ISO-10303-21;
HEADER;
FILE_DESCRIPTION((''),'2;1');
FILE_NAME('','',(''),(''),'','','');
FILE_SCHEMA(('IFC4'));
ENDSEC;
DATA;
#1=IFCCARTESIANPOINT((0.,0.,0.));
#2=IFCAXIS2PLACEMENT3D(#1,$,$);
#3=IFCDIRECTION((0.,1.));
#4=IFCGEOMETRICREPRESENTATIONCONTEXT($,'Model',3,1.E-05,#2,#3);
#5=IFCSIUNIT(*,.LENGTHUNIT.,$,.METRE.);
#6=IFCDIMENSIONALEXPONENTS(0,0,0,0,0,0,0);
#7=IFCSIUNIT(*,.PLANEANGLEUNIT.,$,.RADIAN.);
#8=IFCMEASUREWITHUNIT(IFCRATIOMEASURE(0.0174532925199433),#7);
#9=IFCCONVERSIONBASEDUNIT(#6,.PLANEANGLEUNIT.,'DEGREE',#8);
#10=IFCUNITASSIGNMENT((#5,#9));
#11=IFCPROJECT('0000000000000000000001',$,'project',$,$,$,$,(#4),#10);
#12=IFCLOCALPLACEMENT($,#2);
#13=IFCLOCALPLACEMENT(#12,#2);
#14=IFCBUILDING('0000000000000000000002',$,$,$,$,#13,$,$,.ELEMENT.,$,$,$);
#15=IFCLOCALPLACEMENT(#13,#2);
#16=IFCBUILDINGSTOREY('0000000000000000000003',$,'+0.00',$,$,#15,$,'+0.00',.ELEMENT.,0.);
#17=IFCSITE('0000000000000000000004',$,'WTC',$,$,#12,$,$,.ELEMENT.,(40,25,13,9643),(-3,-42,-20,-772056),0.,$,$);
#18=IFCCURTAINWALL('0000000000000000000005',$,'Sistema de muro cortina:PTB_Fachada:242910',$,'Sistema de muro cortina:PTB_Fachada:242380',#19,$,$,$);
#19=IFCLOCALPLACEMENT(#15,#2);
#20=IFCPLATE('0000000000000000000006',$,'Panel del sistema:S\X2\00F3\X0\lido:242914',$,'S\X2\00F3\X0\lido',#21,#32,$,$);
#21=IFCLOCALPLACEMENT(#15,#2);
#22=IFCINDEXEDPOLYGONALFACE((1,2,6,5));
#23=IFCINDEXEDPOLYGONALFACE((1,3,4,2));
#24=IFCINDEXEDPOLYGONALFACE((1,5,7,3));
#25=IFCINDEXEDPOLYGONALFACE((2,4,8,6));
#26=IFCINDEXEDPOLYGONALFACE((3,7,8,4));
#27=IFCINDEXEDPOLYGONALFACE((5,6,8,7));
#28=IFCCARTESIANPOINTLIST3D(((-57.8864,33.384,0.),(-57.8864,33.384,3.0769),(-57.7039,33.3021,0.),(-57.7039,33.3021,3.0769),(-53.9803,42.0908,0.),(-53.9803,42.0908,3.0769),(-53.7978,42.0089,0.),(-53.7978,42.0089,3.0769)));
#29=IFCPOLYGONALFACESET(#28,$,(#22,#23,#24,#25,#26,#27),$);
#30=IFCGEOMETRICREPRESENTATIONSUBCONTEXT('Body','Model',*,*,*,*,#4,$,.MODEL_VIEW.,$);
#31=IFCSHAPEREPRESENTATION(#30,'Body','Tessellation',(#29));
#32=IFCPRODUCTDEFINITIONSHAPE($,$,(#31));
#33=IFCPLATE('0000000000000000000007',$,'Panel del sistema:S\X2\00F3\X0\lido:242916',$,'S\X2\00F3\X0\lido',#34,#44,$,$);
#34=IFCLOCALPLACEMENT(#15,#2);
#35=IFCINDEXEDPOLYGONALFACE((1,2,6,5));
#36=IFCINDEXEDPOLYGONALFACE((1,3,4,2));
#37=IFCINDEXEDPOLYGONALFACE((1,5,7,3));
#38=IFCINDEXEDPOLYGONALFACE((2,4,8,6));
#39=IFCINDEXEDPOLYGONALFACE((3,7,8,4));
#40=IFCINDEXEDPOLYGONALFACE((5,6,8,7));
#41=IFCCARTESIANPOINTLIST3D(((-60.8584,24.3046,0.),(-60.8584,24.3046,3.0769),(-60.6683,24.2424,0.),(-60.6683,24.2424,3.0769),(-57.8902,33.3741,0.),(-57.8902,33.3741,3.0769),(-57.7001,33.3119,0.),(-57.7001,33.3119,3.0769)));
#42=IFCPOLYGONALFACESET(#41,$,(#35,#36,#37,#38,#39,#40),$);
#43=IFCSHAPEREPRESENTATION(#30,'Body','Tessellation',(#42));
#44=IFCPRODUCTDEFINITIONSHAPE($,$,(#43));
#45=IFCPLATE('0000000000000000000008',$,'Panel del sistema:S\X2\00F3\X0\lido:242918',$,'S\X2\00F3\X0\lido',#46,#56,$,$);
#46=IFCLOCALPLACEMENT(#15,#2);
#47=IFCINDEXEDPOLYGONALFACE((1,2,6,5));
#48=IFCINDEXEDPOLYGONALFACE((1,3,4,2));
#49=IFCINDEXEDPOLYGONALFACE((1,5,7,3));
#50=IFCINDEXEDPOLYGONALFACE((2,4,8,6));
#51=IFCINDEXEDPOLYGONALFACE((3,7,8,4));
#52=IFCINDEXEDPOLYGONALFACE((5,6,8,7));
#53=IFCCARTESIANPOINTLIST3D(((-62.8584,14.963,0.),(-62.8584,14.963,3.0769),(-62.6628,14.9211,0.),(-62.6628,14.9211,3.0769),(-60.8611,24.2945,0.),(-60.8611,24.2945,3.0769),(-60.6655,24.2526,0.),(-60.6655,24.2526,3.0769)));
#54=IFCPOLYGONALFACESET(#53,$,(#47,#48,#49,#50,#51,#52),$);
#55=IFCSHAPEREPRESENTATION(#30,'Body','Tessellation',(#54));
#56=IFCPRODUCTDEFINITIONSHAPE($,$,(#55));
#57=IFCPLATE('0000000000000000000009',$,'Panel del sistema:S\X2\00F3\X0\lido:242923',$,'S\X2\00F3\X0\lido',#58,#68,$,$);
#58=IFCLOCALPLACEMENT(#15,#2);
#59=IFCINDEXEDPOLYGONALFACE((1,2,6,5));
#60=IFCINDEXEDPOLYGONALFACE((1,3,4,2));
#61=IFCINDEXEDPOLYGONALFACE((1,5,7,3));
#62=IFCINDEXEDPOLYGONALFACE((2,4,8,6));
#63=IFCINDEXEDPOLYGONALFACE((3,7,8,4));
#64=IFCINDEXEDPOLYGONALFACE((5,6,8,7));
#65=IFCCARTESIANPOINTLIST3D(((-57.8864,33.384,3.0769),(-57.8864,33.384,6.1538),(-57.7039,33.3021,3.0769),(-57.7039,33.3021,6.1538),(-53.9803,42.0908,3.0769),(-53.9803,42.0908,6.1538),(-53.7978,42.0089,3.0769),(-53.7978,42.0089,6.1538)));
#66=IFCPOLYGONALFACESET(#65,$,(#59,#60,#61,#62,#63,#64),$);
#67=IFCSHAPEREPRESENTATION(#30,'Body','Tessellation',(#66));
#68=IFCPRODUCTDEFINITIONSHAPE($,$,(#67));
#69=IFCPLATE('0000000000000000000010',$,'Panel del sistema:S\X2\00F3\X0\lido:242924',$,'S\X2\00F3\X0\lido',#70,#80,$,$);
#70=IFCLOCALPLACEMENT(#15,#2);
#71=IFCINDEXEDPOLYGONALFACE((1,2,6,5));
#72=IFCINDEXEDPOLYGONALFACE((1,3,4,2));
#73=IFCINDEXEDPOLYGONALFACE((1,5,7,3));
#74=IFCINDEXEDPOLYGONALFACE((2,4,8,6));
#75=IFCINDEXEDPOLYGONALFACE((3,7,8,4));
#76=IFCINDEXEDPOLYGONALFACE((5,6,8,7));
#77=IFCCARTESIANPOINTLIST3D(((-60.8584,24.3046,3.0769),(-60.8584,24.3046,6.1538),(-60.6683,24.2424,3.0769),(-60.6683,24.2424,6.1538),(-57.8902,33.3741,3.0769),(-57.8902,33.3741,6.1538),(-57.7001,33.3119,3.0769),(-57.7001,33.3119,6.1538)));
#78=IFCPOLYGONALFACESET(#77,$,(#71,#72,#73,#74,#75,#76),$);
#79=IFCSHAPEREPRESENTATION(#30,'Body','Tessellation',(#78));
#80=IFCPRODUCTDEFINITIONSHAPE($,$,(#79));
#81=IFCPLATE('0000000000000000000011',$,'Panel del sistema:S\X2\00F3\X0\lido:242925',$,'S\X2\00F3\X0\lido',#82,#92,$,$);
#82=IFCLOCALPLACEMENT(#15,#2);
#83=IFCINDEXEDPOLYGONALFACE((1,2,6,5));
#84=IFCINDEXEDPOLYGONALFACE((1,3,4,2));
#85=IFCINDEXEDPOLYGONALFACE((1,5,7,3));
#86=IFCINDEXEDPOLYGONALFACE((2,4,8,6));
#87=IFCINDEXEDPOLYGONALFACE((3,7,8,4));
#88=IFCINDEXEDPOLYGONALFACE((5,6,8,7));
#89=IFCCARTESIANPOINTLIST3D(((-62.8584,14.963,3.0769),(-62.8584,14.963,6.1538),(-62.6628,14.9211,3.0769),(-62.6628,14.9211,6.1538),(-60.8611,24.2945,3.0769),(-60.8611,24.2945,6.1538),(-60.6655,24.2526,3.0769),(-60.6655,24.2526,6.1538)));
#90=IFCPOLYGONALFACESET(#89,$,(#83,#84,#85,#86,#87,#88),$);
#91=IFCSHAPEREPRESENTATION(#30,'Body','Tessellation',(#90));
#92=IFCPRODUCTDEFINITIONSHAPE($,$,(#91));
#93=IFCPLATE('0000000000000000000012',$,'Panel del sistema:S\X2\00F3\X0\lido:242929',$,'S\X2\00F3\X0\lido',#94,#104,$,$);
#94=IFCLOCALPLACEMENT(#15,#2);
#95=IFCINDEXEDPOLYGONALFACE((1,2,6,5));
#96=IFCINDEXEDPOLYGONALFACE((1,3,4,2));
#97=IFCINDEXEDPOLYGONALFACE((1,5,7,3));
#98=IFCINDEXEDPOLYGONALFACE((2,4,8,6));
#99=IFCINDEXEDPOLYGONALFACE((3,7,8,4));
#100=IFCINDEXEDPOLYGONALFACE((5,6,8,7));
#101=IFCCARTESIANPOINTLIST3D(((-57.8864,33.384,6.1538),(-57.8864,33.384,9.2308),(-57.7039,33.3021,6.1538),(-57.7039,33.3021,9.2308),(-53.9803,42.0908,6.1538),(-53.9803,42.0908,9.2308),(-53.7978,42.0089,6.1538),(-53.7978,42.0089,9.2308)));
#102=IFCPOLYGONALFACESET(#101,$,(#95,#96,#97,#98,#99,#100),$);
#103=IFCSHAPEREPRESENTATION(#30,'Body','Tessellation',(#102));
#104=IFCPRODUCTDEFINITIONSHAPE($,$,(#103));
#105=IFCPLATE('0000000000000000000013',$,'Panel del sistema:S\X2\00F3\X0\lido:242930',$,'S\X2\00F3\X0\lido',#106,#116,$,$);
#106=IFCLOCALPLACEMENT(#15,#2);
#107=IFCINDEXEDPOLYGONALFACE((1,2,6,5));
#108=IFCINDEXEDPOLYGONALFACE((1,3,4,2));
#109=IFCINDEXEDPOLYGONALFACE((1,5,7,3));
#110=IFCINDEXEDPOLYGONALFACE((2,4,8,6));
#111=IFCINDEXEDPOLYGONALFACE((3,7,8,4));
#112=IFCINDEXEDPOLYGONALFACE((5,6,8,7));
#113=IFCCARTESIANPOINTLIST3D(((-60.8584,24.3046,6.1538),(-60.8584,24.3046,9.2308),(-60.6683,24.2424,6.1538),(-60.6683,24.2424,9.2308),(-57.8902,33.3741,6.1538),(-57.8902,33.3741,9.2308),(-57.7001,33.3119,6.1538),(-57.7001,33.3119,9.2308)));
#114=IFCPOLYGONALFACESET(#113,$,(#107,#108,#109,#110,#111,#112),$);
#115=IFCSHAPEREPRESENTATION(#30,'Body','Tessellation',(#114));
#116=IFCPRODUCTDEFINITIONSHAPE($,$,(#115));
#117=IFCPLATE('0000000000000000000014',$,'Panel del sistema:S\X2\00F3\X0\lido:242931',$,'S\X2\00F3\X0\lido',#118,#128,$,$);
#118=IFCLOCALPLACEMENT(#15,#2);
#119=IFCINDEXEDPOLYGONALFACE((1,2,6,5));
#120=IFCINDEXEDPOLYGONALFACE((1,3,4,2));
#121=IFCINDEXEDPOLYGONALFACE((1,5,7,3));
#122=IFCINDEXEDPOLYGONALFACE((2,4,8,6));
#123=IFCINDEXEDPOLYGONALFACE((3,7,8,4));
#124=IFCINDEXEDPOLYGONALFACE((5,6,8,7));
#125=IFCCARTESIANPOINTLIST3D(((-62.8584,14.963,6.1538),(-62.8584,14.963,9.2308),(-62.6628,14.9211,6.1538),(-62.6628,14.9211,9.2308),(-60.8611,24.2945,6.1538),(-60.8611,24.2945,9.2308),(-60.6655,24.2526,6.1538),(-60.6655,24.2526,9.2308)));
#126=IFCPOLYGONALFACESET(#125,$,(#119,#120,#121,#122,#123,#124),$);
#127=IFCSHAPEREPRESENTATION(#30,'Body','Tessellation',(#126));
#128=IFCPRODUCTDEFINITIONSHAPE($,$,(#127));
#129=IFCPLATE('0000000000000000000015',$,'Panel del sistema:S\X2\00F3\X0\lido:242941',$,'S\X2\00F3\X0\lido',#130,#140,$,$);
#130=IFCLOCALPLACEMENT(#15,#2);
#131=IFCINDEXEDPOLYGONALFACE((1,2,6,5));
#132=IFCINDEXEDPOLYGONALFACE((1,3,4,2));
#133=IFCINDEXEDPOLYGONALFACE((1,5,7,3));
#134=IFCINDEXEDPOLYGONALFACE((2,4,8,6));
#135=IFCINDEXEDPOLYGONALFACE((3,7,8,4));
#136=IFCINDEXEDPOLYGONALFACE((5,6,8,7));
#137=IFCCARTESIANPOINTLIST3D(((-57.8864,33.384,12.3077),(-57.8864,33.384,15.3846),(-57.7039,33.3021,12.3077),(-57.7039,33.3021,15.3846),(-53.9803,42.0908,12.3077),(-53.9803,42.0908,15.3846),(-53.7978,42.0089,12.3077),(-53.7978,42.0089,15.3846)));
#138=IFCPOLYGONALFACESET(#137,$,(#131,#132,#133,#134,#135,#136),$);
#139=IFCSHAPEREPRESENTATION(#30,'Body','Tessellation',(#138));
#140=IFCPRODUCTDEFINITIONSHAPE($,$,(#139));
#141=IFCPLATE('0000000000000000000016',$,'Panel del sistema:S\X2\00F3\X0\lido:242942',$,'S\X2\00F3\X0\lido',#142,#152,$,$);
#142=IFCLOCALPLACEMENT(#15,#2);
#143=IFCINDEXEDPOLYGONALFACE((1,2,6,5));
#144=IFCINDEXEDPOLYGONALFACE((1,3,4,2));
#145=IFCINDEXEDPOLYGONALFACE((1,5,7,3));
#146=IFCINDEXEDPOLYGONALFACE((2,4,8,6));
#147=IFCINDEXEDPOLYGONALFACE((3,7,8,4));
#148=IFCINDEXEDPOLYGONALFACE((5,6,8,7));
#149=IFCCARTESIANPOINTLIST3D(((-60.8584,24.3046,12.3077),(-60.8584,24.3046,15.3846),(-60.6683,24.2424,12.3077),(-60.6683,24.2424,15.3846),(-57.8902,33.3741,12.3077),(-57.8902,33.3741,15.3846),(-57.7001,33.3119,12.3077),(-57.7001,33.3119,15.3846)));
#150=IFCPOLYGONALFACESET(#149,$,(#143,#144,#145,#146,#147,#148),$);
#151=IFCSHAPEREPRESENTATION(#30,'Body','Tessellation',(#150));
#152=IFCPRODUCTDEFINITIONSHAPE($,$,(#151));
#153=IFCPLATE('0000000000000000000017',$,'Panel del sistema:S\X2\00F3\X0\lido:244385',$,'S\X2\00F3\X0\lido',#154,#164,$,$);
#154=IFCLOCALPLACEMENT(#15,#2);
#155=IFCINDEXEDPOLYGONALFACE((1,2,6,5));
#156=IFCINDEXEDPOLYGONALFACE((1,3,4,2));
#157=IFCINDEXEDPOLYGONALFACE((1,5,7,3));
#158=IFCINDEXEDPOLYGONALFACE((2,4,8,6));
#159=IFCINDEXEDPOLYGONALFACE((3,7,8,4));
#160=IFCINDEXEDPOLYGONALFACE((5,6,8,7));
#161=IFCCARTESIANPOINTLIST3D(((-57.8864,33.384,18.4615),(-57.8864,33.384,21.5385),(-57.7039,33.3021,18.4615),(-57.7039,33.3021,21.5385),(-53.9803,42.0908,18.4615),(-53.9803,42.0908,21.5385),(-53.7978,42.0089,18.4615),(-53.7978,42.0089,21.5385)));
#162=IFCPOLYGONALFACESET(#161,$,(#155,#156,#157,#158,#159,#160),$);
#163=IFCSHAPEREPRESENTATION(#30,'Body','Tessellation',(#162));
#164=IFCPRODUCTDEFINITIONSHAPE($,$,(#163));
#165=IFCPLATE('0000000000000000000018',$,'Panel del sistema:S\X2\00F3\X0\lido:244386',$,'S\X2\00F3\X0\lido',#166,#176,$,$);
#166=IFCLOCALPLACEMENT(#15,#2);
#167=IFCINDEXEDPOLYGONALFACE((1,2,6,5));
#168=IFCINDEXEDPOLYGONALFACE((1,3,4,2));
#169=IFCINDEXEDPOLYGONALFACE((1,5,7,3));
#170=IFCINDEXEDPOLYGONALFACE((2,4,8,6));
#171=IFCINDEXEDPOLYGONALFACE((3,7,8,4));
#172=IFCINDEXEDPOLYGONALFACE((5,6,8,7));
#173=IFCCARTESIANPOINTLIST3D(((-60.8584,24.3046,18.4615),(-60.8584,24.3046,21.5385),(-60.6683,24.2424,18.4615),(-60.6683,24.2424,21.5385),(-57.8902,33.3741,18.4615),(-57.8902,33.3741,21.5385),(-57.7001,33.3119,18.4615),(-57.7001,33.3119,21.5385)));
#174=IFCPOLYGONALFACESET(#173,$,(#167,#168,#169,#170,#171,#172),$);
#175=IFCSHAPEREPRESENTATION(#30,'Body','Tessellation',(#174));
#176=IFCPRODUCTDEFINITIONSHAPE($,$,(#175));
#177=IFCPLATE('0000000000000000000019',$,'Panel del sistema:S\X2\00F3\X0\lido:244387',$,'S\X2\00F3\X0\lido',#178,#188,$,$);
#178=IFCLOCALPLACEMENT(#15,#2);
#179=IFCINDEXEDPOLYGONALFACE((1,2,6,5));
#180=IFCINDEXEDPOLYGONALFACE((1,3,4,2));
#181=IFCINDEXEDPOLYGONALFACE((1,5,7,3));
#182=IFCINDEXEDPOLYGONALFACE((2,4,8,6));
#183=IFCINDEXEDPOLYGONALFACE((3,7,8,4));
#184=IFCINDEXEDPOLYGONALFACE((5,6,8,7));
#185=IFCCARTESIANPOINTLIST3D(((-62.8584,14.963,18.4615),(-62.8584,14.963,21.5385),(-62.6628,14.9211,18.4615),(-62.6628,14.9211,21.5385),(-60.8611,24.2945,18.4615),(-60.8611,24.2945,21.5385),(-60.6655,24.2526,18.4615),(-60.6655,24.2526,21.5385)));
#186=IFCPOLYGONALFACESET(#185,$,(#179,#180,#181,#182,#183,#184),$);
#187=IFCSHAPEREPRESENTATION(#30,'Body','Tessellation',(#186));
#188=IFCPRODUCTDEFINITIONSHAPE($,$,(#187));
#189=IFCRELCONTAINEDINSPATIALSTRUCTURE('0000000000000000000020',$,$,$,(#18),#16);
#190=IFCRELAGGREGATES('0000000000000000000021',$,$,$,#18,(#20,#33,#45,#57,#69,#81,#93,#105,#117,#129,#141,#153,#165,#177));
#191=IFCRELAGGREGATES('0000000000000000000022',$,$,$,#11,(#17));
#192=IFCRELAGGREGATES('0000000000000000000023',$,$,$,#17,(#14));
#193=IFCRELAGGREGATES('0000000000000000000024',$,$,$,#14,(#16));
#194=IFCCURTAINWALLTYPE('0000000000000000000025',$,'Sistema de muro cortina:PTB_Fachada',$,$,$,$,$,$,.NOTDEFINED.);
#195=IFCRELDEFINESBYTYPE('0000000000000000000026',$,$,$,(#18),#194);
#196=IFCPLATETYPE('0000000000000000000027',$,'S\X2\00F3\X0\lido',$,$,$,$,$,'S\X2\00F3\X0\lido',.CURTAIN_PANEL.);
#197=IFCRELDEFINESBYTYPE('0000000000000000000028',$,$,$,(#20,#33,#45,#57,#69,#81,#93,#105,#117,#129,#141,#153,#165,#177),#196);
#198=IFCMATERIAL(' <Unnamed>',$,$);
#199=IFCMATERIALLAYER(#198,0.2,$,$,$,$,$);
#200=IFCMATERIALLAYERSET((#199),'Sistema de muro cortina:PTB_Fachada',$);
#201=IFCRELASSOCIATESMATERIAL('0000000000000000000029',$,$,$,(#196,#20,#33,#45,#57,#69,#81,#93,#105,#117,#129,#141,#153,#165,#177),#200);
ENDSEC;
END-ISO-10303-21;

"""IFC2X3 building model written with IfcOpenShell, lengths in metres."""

from ifc_helpers import new_model, entity, si_unit, converted_unit, direction, frame, frame_2d, origin, place, context, subcontext, project, spatial, rectangle, extrude, source, transform, mapped, material, layer, layer_set, layer_usage, type_object, type_shapes, element, aggregate, save


model = new_model("IFC2X3")

# Units and contexts
model_context = context("Model", 3, precision=1e-05, world=origin(), true_north=direction((0.0, 1.0)))
body_context = subcontext(model_context, "Body", "Model", "MODEL_VIEW")
ifc_project = project(units=[si_unit("LENGTHUNIT", "METRE"), converted_unit("PLANEANGLEUNIT", "DEGREE", entity("IfcRatioMeasure", 0.0174532925199433), si_unit("PLANEANGLEUNIT", "RADIAN"), dimensions=[0, 0, 0, 0, 0, 0, 0])], contexts=[model_context])

# Site, building, storey
site_placement = place(None, origin())
site = spatial("IfcSite", under=ifc_project, at=site_placement, Name="WTC", CompositionType="ELEMENT", RefLatitude=(40, 25, 13, 9643), RefLongitude=(-3, -42, -20, -772056), RefElevation=0.0)
building_placement = place(site_placement, origin())
building = spatial("IfcBuilding", under=site, at=building_placement, CompositionType="ELEMENT")
storey_placement = place(building_placement, origin())
storey = spatial("IfcBuildingStorey", under=building, at=storey_placement, Name="+0.00", LongName="+0.00", CompositionType="ELEMENT", Elevation=0.0)

# Curtain wall, plates
curtain_wall_type = type_object("IfcCurtainWallType", Name="Sistema de muro cortina:PTB_Fachada", PredefinedType="NOTDEFINED")
curtain_wall_placement = place(storey_placement, origin())
curtain_wall = element("IfcCurtainWall", 1, at=curtain_wall_placement, inside=storey, type_object=curtain_wall_type, Name="Sistema de muro cortina:PTB_Fachada:242910", ObjectType="Sistema de muro cortina:PTB_Fachada:242380")
ifc_material_1 = material(Name=" <Unnamed>")
ifc_layer_1 = layer(ifc_material_1, 0.2)
ifc_layer_set_1 = layer_set([ifc_layer_1], Name="Sistema de muro cortina:PTB_Fachada")
ifc_layer_usage_1 = layer_usage(ifc_layer_set_1, "AXIS3", "POSITIVE", 0.0)
plate_type_1 = type_object("IfcPlateType", Name="Sólido", ElementType="Sólido", PredefinedType="CURTAIN_PANEL", material=ifc_layer_set_1)
shared_shape_1 = source(origin(), body_context, "Body", "SweptSolid", [
    extrude(rectangle(XDim=0.2, YDim=9.5428, at=frame_2d((0.0, 0.0), x_axis=(1.0, 0.0))), frame((0.0, 0.0, 0.0), z_axis=(0.0, 0.0, 1.0), x_axis=(0.0, 1.0, 0.0)), (0.0, 0.0, 1.0), 3.0769),
])
type_shapes(plate_type_1, [shared_shape_1])
plate_1_placement = place(curtain_wall_placement, frame((-55.8421, 37.6964, 0.0), z_axis=(0.0, 0.0, 1.0), x_axis=(-0.409321, -0.91239, 0.0)))
plate_1 = element("IfcPlate", 2, at=plate_1_placement, type_object=plate_type_1, material=ifc_layer_usage_1, Name="Panel del sistema:Sólido:242914", ObjectType="Sólido", context=body_context, shape_type="MappedRepresentation", body=[
    mapped(shared_shape_1, transform((0.0, 0.0, 0.0), scale=1.0)),
])
ifc_layer_usage_2 = layer_usage(ifc_layer_set_1, "AXIS3", "POSITIVE", 0.0)
plate_2_placement = place(curtain_wall_placement, frame((-59.2792, 28.8083, 0.0), z_axis=(0.0, 0.0, 1.0), x_axis=(-0.311036, -0.950398, 0.0)))
plate_2 = element("IfcPlate", 3, at=plate_2_placement, type_object=plate_type_1, material=ifc_layer_usage_2, Name="Panel del sistema:Sólido:242916", ObjectType="Sólido", context=body_context, shape_type="MappedRepresentation", body=[
    mapped(shared_shape_1, transform((0.0, 0.0, 0.0), scale=1.0)),
])
ifc_layer_usage_3 = layer_usage(ifc_layer_set_1, "AXIS3", "POSITIVE", 0.0)
plate_3_placement = place(curtain_wall_placement, frame((-61.762, 19.6078, 0.0), z_axis=(0.0, 0.0, 1.0), x_axis=(-0.209296, -0.977852, 0.0)))
plate_3 = element("IfcPlate", 4, at=plate_3_placement, type_object=plate_type_1, material=ifc_layer_usage_3, Name="Panel del sistema:Sólido:242918", ObjectType="Sólido", context=body_context, shape_type="MappedRepresentation", body=[
    mapped(shared_shape_1, transform((0.0, 0.0, 0.0), scale=1.0)),
])
ifc_layer_usage_4 = layer_usage(ifc_layer_set_1, "AXIS3", "POSITIVE", 0.0)
plate_4_placement = place(curtain_wall_placement, frame((-55.8421, 37.6964, 3.0769), z_axis=(0.0, 0.0, 1.0), x_axis=(-0.409321, -0.91239, 0.0)))
plate_4 = element("IfcPlate", 5, at=plate_4_placement, type_object=plate_type_1, material=ifc_layer_usage_4, Name="Panel del sistema:Sólido:242923", ObjectType="Sólido", context=body_context, shape_type="MappedRepresentation", body=[
    mapped(shared_shape_1, transform((0.0, 0.0, 0.0), scale=1.0)),
])
ifc_layer_usage_5 = layer_usage(ifc_layer_set_1, "AXIS3", "POSITIVE", 0.0)
plate_5_placement = place(curtain_wall_placement, frame((-59.2792, 28.8083, 3.0769), z_axis=(0.0, 0.0, 1.0), x_axis=(-0.311036, -0.950398, 0.0)))
plate_5 = element("IfcPlate", 6, at=plate_5_placement, type_object=plate_type_1, material=ifc_layer_usage_5, Name="Panel del sistema:Sólido:242924", ObjectType="Sólido", context=body_context, shape_type="MappedRepresentation", body=[
    mapped(shared_shape_1, transform((0.0, 0.0, 0.0), scale=1.0)),
])
ifc_layer_usage_6 = layer_usage(ifc_layer_set_1, "AXIS3", "POSITIVE", 0.0)
plate_6_placement = place(curtain_wall_placement, frame((-61.762, 19.6078, 3.0769), z_axis=(0.0, 0.0, 1.0), x_axis=(-0.209296, -0.977852, 0.0)))
plate_6 = element("IfcPlate", 7, at=plate_6_placement, type_object=plate_type_1, material=ifc_layer_usage_6, Name="Panel del sistema:Sólido:242925", ObjectType="Sólido", context=body_context, shape_type="MappedRepresentation", body=[
    mapped(shared_shape_1, transform((0.0, 0.0, 0.0), scale=1.0)),
])
ifc_layer_usage_7 = layer_usage(ifc_layer_set_1, "AXIS3", "POSITIVE", 0.0)
plate_7_placement = place(curtain_wall_placement, frame((-55.8421, 37.6964, 6.1538), z_axis=(0.0, 0.0, 1.0), x_axis=(-0.409321, -0.91239, 0.0)))
plate_7 = element("IfcPlate", 8, at=plate_7_placement, type_object=plate_type_1, material=ifc_layer_usage_7, Name="Panel del sistema:Sólido:242929", ObjectType="Sólido", context=body_context, shape_type="MappedRepresentation", body=[
    mapped(shared_shape_1, transform((0.0, 0.0, 0.0), scale=1.0)),
])
ifc_layer_usage_8 = layer_usage(ifc_layer_set_1, "AXIS3", "POSITIVE", 0.0)
plate_8_placement = place(curtain_wall_placement, frame((-59.2792, 28.8083, 6.1538), z_axis=(0.0, 0.0, 1.0), x_axis=(-0.311036, -0.950398, 0.0)))
plate_8 = element("IfcPlate", 9, at=plate_8_placement, type_object=plate_type_1, material=ifc_layer_usage_8, Name="Panel del sistema:Sólido:242930", ObjectType="Sólido", context=body_context, shape_type="MappedRepresentation", body=[
    mapped(shared_shape_1, transform((0.0, 0.0, 0.0), scale=1.0)),
])
ifc_layer_usage_9 = layer_usage(ifc_layer_set_1, "AXIS3", "POSITIVE", 0.0)
plate_9_placement = place(curtain_wall_placement, frame((-61.762, 19.6078, 6.1538), z_axis=(0.0, 0.0, 1.0), x_axis=(-0.209296, -0.977852, 0.0)))
plate_9 = element("IfcPlate", 10, at=plate_9_placement, type_object=plate_type_1, material=ifc_layer_usage_9, Name="Panel del sistema:Sólido:242931", ObjectType="Sólido", context=body_context, shape_type="MappedRepresentation", body=[
    mapped(shared_shape_1, transform((0.0, 0.0, 0.0), scale=1.0)),
])
ifc_layer_usage_10 = layer_usage(ifc_layer_set_1, "AXIS3", "POSITIVE", 0.0)
plate_10_placement = place(curtain_wall_placement, frame((-55.8421, 37.6964, 12.3077), z_axis=(0.0, 0.0, 1.0), x_axis=(-0.409321, -0.91239, 0.0)))
plate_10 = element("IfcPlate", 11, at=plate_10_placement, type_object=plate_type_1, material=ifc_layer_usage_10, Name="Panel del sistema:Sólido:242941", ObjectType="Sólido", context=body_context, shape_type="MappedRepresentation", body=[
    mapped(shared_shape_1, transform((0.0, 0.0, 0.0), scale=1.0)),
])
ifc_layer_usage_11 = layer_usage(ifc_layer_set_1, "AXIS3", "POSITIVE", 0.0)
plate_11_placement = place(curtain_wall_placement, frame((-59.2792, 28.8083, 12.3077), z_axis=(0.0, 0.0, 1.0), x_axis=(-0.311036, -0.950398, 0.0)))
plate_11 = element("IfcPlate", 12, at=plate_11_placement, type_object=plate_type_1, material=ifc_layer_usage_11, Name="Panel del sistema:Sólido:242942", ObjectType="Sólido", context=body_context, shape_type="MappedRepresentation", body=[
    mapped(shared_shape_1, transform((0.0, 0.0, 0.0), scale=1.0)),
])
ifc_layer_usage_12 = layer_usage(ifc_layer_set_1, "AXIS3", "POSITIVE", 0.0)
plate_12_placement = place(curtain_wall_placement, frame((-55.8421, 37.6964, 18.4615), z_axis=(0.0, 0.0, 1.0), x_axis=(-0.409321, -0.91239, 0.0)))
plate_12 = element("IfcPlate", 13, at=plate_12_placement, type_object=plate_type_1, material=ifc_layer_usage_12, Name="Panel del sistema:Sólido:244385", ObjectType="Sólido", context=body_context, shape_type="MappedRepresentation", body=[
    mapped(shared_shape_1, transform((0.0, 0.0, 0.0), scale=1.0)),
])
ifc_layer_usage_13 = layer_usage(ifc_layer_set_1, "AXIS3", "POSITIVE", 0.0)
plate_13_placement = place(curtain_wall_placement, frame((-59.2792, 28.8083, 18.4615), z_axis=(0.0, 0.0, 1.0), x_axis=(-0.311036, -0.950398, 0.0)))
plate_13 = element("IfcPlate", 14, at=plate_13_placement, type_object=plate_type_1, material=ifc_layer_usage_13, Name="Panel del sistema:Sólido:244386", ObjectType="Sólido", context=body_context, shape_type="MappedRepresentation", body=[
    mapped(shared_shape_1, transform((0.0, 0.0, 0.0), scale=1.0)),
])
ifc_layer_usage_14 = layer_usage(ifc_layer_set_1, "AXIS3", "POSITIVE", 0.0)
plate_14_placement = place(curtain_wall_placement, frame((-61.762, 19.6078, 18.4615), z_axis=(0.0, 0.0, 1.0), x_axis=(-0.209296, -0.977852, 0.0)))
plate_14 = element("IfcPlate", 15, at=plate_14_placement, type_object=plate_type_1, material=ifc_layer_usage_14, Name="Panel del sistema:Sólido:244387", ObjectType="Sólido", context=body_context, shape_type="MappedRepresentation", body=[
    mapped(shared_shape_1, transform((0.0, 0.0, 0.0), scale=1.0)),
])
aggregate(curtain_wall, [plate_1, plate_2, plate_3, plate_4, plate_5, plate_6, plate_7, plate_8, plate_9, plate_10, plate_11, plate_12, plate_13, plate_14])

save(model, "model.ifc")
